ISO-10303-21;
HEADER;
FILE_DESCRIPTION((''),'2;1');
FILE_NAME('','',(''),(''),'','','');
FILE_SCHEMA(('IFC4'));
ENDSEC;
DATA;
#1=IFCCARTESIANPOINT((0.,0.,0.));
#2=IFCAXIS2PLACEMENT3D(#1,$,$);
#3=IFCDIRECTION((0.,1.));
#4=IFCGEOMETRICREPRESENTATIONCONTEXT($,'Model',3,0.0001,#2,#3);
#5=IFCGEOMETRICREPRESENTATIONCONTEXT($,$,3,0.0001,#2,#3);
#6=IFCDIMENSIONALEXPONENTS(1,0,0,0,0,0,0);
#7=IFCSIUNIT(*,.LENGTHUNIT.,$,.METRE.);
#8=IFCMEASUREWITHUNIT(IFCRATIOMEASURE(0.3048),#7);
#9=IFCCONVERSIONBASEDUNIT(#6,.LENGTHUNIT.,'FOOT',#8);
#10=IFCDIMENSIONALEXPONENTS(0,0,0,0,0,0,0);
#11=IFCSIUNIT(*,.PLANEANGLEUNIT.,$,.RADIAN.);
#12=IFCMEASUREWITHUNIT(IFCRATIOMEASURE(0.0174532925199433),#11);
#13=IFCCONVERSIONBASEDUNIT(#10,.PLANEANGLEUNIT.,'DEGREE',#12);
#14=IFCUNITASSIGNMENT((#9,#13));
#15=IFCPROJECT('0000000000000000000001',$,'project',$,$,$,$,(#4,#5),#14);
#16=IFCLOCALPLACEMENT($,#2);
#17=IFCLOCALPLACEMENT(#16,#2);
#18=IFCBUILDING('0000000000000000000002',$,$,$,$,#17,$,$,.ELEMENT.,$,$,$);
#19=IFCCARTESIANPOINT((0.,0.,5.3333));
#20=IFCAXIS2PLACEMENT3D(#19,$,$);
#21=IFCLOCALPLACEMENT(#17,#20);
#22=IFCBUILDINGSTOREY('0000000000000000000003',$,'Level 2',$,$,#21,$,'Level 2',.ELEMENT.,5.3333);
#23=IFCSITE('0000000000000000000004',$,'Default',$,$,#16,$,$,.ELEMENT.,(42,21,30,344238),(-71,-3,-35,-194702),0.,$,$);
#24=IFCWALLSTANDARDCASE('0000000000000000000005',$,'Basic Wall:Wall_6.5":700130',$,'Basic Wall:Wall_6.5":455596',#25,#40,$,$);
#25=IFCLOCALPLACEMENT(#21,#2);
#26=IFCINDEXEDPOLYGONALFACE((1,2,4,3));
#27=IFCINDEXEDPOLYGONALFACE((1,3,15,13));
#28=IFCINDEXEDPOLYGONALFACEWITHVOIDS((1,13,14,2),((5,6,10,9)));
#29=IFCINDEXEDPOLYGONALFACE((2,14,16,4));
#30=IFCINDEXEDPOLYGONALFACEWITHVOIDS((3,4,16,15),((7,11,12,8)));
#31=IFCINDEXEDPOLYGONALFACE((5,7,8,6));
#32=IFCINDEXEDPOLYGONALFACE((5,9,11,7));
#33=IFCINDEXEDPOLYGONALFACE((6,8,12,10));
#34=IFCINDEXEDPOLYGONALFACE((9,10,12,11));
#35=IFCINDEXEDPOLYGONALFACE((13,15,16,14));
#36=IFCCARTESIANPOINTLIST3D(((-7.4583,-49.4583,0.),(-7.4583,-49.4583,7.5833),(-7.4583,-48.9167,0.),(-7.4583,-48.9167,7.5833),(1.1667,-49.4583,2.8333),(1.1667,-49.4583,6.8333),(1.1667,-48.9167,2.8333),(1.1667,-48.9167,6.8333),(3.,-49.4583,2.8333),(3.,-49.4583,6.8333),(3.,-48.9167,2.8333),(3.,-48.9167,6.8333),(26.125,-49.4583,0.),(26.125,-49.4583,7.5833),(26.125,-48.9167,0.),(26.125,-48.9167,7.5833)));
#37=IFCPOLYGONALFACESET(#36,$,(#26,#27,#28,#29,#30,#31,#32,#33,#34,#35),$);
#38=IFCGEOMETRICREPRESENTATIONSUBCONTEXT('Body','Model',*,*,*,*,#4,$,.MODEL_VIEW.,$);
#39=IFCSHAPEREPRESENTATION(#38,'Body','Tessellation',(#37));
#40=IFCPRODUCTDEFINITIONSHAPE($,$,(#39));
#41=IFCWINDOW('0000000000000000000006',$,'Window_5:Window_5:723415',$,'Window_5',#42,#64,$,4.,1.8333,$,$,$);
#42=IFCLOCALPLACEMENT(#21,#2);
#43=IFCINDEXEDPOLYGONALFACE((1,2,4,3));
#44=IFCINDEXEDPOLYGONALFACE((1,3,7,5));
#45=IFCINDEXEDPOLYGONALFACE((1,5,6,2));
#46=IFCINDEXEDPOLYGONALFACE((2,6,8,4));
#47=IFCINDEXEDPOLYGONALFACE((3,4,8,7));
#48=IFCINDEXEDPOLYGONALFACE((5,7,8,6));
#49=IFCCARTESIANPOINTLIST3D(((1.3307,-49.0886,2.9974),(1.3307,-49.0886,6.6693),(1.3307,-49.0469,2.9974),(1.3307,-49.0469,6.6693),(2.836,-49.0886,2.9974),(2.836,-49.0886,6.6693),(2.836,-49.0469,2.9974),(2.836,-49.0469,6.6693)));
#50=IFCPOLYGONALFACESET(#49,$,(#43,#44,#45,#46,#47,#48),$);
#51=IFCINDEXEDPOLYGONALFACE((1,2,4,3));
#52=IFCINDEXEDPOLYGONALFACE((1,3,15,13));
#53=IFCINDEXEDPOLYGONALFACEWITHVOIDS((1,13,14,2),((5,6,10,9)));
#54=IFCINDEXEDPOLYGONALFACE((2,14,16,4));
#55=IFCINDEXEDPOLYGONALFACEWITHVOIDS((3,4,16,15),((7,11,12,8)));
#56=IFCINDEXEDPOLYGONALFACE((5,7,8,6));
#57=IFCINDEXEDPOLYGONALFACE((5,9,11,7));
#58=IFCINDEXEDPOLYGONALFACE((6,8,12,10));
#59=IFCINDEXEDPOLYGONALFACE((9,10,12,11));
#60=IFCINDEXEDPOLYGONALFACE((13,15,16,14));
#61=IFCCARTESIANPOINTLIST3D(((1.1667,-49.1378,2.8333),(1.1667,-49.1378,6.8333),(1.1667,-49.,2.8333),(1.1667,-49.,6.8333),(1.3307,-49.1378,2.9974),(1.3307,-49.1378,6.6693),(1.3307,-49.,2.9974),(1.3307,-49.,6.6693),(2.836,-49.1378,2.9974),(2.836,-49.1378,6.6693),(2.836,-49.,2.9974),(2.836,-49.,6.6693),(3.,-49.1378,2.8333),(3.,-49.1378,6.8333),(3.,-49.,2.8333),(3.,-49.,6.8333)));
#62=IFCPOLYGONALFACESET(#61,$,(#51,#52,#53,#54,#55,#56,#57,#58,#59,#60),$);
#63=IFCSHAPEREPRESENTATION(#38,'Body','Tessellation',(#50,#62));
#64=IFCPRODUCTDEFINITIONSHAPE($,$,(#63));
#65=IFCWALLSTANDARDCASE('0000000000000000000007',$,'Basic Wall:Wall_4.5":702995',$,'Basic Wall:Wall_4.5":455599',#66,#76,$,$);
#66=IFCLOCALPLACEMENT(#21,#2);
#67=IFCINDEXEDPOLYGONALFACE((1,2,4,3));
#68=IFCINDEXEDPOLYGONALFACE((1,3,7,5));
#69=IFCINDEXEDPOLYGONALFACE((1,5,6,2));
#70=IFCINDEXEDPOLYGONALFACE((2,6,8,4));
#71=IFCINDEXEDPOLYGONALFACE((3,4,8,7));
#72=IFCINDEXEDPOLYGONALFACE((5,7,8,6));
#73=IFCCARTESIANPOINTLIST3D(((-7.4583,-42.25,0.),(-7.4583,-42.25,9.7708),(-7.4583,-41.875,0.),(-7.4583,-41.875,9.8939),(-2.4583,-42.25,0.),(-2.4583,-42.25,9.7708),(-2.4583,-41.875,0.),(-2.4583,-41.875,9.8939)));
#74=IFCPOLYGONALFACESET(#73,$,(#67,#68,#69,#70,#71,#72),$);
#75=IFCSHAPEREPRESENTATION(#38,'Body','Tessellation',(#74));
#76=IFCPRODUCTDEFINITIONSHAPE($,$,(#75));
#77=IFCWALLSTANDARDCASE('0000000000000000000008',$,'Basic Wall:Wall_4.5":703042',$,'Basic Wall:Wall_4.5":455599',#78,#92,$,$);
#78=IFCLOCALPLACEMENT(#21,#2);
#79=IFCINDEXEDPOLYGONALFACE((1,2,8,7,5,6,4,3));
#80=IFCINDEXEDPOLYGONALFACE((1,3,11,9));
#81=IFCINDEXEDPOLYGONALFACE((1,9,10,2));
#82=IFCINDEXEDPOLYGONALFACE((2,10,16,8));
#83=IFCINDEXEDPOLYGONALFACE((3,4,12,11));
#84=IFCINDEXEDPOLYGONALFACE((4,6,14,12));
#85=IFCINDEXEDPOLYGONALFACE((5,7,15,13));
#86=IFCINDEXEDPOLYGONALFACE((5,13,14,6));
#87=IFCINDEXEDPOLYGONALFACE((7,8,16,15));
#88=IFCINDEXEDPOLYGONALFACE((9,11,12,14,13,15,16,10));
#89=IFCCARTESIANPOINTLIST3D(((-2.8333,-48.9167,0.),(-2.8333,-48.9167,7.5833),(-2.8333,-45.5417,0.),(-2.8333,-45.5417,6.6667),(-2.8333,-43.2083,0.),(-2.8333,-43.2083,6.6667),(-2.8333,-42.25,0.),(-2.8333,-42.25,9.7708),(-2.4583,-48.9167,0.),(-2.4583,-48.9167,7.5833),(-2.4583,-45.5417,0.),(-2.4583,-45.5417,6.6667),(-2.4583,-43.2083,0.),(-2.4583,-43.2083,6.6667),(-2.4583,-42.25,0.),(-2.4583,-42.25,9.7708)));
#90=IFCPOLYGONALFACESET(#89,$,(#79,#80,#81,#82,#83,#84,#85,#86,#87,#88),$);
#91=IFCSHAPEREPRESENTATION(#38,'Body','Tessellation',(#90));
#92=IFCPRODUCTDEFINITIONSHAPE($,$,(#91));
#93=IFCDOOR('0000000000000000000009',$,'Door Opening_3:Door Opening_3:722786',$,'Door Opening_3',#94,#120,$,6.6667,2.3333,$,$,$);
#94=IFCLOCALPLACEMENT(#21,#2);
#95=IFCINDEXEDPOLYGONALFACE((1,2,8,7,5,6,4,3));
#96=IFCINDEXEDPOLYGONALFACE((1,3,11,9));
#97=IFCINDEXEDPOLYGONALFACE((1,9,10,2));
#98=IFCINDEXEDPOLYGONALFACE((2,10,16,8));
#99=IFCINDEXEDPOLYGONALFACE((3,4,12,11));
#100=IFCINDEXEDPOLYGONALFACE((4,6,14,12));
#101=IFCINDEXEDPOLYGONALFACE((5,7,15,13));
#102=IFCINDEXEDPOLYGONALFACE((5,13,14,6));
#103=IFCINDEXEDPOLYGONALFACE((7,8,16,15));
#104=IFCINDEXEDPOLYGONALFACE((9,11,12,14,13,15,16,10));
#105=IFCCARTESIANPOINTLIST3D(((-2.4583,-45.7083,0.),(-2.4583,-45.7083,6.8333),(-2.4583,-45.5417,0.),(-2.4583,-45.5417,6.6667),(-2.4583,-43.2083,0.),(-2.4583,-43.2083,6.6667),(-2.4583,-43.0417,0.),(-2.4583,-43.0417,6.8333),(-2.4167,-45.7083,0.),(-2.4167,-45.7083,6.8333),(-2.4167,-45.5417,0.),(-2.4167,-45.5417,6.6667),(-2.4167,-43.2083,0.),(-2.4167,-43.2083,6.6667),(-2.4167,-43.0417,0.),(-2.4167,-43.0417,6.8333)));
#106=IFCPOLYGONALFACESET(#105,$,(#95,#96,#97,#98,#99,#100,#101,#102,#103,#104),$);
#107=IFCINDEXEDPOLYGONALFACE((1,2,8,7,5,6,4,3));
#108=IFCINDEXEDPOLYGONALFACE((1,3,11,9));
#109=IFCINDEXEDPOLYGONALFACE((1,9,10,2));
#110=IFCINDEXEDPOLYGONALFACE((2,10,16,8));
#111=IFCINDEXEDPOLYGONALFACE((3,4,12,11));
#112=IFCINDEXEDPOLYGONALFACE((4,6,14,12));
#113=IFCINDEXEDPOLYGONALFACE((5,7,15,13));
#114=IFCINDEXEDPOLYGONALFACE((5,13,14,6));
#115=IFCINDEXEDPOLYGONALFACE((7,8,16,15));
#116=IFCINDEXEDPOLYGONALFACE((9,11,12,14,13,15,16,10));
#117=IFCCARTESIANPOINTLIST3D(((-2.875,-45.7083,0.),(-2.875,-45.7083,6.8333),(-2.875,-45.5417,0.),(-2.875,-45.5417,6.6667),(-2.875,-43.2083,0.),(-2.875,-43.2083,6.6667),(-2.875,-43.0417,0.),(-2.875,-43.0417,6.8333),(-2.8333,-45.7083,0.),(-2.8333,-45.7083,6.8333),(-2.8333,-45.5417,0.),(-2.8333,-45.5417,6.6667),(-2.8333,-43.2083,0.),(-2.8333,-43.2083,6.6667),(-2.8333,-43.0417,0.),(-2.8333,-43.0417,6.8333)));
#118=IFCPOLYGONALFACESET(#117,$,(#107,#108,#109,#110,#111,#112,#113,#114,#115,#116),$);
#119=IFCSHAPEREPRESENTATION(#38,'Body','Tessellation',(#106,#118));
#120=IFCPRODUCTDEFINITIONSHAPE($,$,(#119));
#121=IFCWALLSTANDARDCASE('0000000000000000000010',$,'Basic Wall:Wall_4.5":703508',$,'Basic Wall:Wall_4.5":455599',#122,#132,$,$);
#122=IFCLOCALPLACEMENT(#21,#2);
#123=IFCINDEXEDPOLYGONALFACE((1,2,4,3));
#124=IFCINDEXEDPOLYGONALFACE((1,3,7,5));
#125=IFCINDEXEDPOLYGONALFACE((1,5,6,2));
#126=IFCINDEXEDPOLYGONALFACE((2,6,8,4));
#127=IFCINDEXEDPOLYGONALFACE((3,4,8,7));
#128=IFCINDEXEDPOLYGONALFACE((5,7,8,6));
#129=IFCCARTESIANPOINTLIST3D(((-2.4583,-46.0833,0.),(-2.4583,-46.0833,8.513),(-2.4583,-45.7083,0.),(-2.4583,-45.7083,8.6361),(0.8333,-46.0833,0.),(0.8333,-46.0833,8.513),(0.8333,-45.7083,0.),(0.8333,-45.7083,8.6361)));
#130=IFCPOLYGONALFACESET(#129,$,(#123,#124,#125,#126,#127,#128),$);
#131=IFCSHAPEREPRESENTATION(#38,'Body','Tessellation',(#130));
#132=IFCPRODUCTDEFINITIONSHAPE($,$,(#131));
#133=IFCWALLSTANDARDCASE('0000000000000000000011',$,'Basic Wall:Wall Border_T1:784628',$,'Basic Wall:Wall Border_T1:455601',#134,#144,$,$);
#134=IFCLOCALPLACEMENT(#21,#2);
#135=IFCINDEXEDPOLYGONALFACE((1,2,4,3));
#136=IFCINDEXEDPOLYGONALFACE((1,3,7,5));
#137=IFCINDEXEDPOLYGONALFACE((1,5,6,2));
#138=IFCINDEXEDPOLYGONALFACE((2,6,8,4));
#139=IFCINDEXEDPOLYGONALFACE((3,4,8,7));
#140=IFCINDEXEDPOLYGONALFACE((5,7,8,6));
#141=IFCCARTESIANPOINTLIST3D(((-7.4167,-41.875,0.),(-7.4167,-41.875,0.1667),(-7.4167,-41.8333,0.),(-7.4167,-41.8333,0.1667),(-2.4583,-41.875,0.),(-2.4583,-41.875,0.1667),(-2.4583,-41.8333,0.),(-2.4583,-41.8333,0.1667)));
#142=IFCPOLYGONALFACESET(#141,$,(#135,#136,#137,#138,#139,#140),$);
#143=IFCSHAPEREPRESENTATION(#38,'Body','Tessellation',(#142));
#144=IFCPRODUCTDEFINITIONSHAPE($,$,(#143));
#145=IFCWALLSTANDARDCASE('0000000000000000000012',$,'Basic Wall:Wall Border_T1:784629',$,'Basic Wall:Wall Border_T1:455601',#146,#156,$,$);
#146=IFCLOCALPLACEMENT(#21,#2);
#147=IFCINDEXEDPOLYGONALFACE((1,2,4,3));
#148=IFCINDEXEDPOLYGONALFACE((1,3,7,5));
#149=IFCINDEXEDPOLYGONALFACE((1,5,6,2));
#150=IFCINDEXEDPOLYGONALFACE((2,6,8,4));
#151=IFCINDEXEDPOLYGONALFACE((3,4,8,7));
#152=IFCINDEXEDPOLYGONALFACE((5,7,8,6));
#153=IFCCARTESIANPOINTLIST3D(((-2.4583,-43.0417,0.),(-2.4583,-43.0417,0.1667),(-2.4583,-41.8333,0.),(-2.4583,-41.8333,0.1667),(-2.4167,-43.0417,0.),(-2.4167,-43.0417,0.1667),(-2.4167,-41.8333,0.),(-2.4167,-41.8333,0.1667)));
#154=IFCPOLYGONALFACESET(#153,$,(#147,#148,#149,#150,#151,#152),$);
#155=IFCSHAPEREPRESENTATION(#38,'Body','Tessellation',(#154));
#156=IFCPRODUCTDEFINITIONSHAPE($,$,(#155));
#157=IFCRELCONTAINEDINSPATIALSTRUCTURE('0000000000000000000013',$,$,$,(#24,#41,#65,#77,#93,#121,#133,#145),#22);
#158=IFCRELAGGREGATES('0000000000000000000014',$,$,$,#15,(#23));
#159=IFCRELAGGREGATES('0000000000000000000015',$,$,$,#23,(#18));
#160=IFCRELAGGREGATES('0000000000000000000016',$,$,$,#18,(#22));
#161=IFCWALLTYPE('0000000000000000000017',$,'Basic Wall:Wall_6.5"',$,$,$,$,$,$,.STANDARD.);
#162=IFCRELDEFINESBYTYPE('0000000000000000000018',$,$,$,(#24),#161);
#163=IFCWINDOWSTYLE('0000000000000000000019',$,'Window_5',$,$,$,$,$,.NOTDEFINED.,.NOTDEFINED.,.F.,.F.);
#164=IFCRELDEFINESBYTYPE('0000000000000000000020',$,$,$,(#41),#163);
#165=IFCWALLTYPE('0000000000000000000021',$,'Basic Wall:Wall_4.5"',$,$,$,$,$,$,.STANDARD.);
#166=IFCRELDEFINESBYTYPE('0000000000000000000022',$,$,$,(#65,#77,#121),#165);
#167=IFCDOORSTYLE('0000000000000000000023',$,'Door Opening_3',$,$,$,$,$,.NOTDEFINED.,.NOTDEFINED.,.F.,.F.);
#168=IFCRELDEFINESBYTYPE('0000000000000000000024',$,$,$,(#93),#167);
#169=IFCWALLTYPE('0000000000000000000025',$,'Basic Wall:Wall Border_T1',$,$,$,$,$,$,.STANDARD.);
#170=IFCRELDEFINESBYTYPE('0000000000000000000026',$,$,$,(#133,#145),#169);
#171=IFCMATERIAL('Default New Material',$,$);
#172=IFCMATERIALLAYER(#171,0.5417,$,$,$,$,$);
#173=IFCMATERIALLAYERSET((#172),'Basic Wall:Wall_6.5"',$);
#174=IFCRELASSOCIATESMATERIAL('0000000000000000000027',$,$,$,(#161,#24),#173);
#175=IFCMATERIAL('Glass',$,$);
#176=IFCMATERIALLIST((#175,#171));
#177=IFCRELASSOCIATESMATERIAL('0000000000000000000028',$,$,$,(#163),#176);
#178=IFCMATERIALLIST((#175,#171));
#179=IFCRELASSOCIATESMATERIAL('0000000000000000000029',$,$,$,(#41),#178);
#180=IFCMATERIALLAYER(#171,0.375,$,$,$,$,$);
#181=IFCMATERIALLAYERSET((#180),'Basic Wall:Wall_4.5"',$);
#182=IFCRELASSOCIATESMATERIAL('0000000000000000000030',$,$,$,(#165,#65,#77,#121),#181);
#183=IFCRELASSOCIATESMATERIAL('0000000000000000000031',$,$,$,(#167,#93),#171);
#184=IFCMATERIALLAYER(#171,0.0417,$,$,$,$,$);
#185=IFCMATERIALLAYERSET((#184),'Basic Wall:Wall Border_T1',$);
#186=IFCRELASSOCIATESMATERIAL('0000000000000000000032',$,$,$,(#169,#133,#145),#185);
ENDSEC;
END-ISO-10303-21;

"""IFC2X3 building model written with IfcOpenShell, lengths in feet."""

from ifc_helpers import new_model, entity, si_unit, converted_unit, direction, frame, frame_2d, origin, origin_2d_with_axis, place, context, subcontext, project, spatial, polyline, rectangle, outline, extrude, clip, bounded_halfspace, source, transform, mapped, material, material_list, layer, layer_set, layer_usage, type_object, type_shapes, element, fill, save


model = new_model("IFC2X3")

# Units and contexts
model_context = context("Model", 3, precision=0.0001, world=origin(), true_north=direction((0.0, 1.0)))
context_of_model = context(None, 3, precision=0.0001, world=origin(), true_north=direction((0.0, 1.0)))
body_context = subcontext(model_context, "Body", "Model", "MODEL_VIEW")
ifc_project = project(units=[converted_unit("LENGTHUNIT", "FOOT", entity("IfcRatioMeasure", 0.3048), si_unit("LENGTHUNIT", "METRE"), dimensions=[1, 0, 0, 0, 0, 0, 0]), converted_unit("PLANEANGLEUNIT", "DEGREE", entity("IfcRatioMeasure", 0.0174532925199433), si_unit("PLANEANGLEUNIT", "RADIAN"), dimensions=[0, 0, 0, 0, 0, 0, 0])], contexts=[model_context, context_of_model])

# Site, building, storey
site_placement = place(None, origin())
site = spatial("IfcSite", under=ifc_project, at=site_placement, Name="Default", CompositionType="ELEMENT", RefLatitude=(42, 21, 30, 344238), RefLongitude=(-71, -3, -35, -194702), RefElevation=0.0)
building_placement = place(site_placement, origin())
building = spatial("IfcBuilding", under=site, at=building_placement, CompositionType="ELEMENT")
storey_placement = place(building_placement, frame((0.0, 0.0, 5.3333)))
storey = spatial("IfcBuildingStorey", under=building, at=storey_placement, Name="Level 2", LongName="Level 2", CompositionType="ELEMENT", Elevation=5.3333)

# Wall, opening, window
ifc_material_1 = material(Name="Default New Material")
ifc_layer_1 = layer(ifc_material_1, 0.5417)
ifc_layer_set_1 = layer_set([ifc_layer_1], Name="Basic Wall:Wall_6.5\"")
ifc_layer_usage_1 = layer_usage(ifc_layer_set_1, "AXIS2", "NEGATIVE", 0.2708)
wall_type_1 = type_object("IfcWallType", Name="Basic Wall:Wall_6.5\"", PredefinedType="STANDARD", material=ifc_layer_set_1)
wall_1_placement = place(storey_placement, frame((-7.4583, -49.1875, 0.0)))
wall_1 = element("IfcWallStandardCase", 1, at=wall_1_placement, inside=storey, type_object=wall_type_1, material=ifc_layer_usage_1, Name="Basic Wall:Wall_6.5\":700130", ObjectType="Basic Wall:Wall_6.5\":455596", context=body_context, shape_type="SweptSolid", body=[
    extrude(rectangle(XDim=33.5833, YDim=0.5417, at=frame_2d((16.7917, 0.0), x_axis=(-1.0, 0.0))), origin(), (0.0, 0.0, 1.0), 7.5833),
])
opening_1_placement = place(wall_1_placement, frame((8.625, -0.2708, 2.8333)))
opening_1 = element("IfcOpeningElement", 2, at=opening_1_placement, cuts=wall_1, ObjectType="Opening", context=body_context, shape_type="SweptSolid", body=[
    extrude(rectangle(XDim=4.0, YDim=1.8333, at=frame_2d((2.0, 0.9167), x_axis=(-1.0, 0.0))), frame((0.0, 0.0, 0.0), z_axis=(0.0, 1.0, 0.0), x_axis=(0.0, 0.0, 1.0)), (0.0, 0.0, 1.0), 0.5417),
])
ifc_material_2 = material(Name="Glass")
ifc_material_list_1 = material_list([ifc_material_2, ifc_material_1])
ifc_material_list_2 = material_list([ifc_material_2, ifc_material_1])
window_style = type_object("IfcWindowStyle", Name="Window_5", ConstructionType="NOTDEFINED", OperationType="NOTDEFINED", ParameterTakesPrecedence=False, Sizeable=False, material=ifc_material_list_2)
shared_shape_1 = source(origin(), body_context, "Body", "SweptSolid", [
    extrude(rectangle(XDim=0.0417, YDim=1.5052, at=origin_2d_with_axis()), frame((0.9167, 0.3906, 0.164), z_axis=(0.0, 0.0, 1.0), x_axis=(0.0, 1.0, 0.0)), (0.0, 0.0, 1.0), 3.6719),
    extrude(outline(polyline([(-0.9167, -2.0), (0.9167, -2.0), (0.9167, 2.0), (-0.9167, 2.0), (-0.9167, -2.0)]), holes=[polyline([(-0.7526, -1.836), (-0.7526, 1.836), (0.7526, 1.836), (0.7526, -1.836), (-0.7526, -1.836)])]), frame((0.9167, 0.3205, 2.0), z_axis=(0.0, 1.0, 0.0), x_axis=(1.0, 0.0, 0.0)), (0.0, 0.0, 1.0), 0.1378),
])
type_shapes(window_style, [shared_shape_1])
window_placement = place(opening_1_placement, origin())
window = element("IfcWindow", 3, at=window_placement, inside=storey, type_object=window_style, material=ifc_material_list_1, Name="Window_5:Window_5:723415", ObjectType="Window_5", OverallHeight=4.0, OverallWidth=1.8333, context=body_context, shape_type="MappedRepresentation", body=[
    mapped(shared_shape_1, transform((0.0, 0.0, 0.0), scale=1.0)),
])
fill(opening_1, window)

# Wall
ifc_layer_2 = layer(ifc_material_1, 0.375)
ifc_layer_set_2 = layer_set([ifc_layer_2], Name="Basic Wall:Wall_4.5\"")
ifc_layer_usage_2 = layer_usage(ifc_layer_set_2, "AXIS2", "NEGATIVE", 0.1875)
wall_type_2 = type_object("IfcWallType", Name="Basic Wall:Wall_4.5\"", PredefinedType="STANDARD", material=ifc_layer_set_2)
wall_2_placement = place(storey_placement, frame((-7.4583, -42.0625, 0.0)))
element("IfcWallStandardCase", 4, at=wall_2_placement, inside=storey, type_object=wall_type_2, material=ifc_layer_usage_2, Name="Basic Wall:Wall_4.5\":702995", ObjectType="Basic Wall:Wall_4.5\":455599", context=body_context, shape_type="Clipping", body=[
    clip(extrude(rectangle(XDim=5.0, YDim=0.375, at=frame_2d((2.5, 0.0), x_axis=(-1.0, 0.0))), origin(), (0.0, 0.0, 1.0), 9.8939), bounded_halfspace(frame((0.0, -0.1875, 9.7708), z_axis=(0.0, 0.31177, -0.950157), x_axis=(1.0, 0.0, 0.0)), True, frame((0.0, -0.1875, 9.7708)), polyline([(0.0, 0.0), (4.625, 0.0), (5.0, 0.0), (5.0, 0.375), (0.0, 0.375), (0.0, 0.0)]))),
])

# Wall, opening, door
ifc_layer_usage_3 = layer_usage(ifc_layer_set_2, "AXIS2", "NEGATIVE", 0.1875)
wall_3_placement = place(storey_placement, frame((-2.6458, -42.25, 0.0), z_axis=(0.0, 0.0, 1.0), x_axis=(0.0, -1.0, 0.0)))
wall_3 = element("IfcWallStandardCase", 5, at=wall_3_placement, inside=storey, type_object=wall_type_2, material=ifc_layer_usage_3, Name="Basic Wall:Wall_4.5\":703042", ObjectType="Basic Wall:Wall_4.5\":455599", context=body_context, shape_type="Clipping", body=[
    clip(extrude(rectangle(XDim=6.6667, YDim=0.375, at=frame_2d((3.3333, 0.0), x_axis=(-1.0, 0.0))), origin(), (0.0, 0.0, 1.0), 9.7708), bounded_halfspace(frame((0.0, -0.1875, 9.7708), z_axis=(-0.31177, 0.0, -0.950157), x_axis=(0.0, 1.0, 0.0)), True, frame((0.0, -0.1875, 9.7708)), polyline([(0.0, 0.0), (6.6667, 0.0), (6.6667, 0.375), (3.8333, 0.375), (3.4583, 0.375), (0.0, 0.375), (0.0, 0.0)]))),
])
opening_2_placement = place(wall_3_placement, frame((0.9583, -0.1875, 0.0)))
opening_2 = element("IfcOpeningElement", 6, at=opening_2_placement, cuts=wall_3, ObjectType="Opening", context=body_context, shape_type="SweptSolid", body=[
    extrude(rectangle(XDim=2.3333, YDim=6.6667, at=frame_2d((3.3333, 1.1667), x_axis=(0.0, 1.0))), frame((0.0, 0.0, 0.0), z_axis=(0.0, 1.0, 0.0), x_axis=(0.0, 0.0, 1.0)), (0.0, 0.0, 1.0), 0.375),
])
door_style = type_object("IfcDoorStyle", Name="Door Opening_3", ConstructionType="NOTDEFINED", OperationType="NOTDEFINED", ParameterTakesPrecedence=False, Sizeable=False, material=ifc_material_1)
shared_shape_2 = source(origin(), body_context, "Body", "SweptSolid", [
    extrude(outline(polyline([(-1.3333, -3.4583), (1.3333, -3.4583), (1.3333, 3.375), (1.1667, 3.375), (1.1667, -3.2917), (-1.1667, -3.2917), (-1.1667, 3.375), (-1.3333, 3.375), (-1.3333, -3.4583)])), frame((1.1667, 0.375, 3.375), z_axis=(0.0, 1.0, 0.0), x_axis=(1.0, 0.0, 0.0)), (0.0, 0.0, 1.0), 0.0417),
    extrude(outline(polyline([(-3.4583, -1.3333), (3.375, -1.3333), (3.375, -1.1667), (-3.2917, -1.1667), (-3.2917, 1.1667), (3.375, 1.1667), (3.375, 1.3333), (-3.4583, 1.3333), (-3.4583, -1.3333)])), frame((1.1667, -0.0417, 3.375), z_axis=(0.0, 1.0, 0.0), x_axis=(0.0, 0.0, -1.0)), (0.0, 0.0, 1.0), 0.0417),
])
type_shapes(door_style, [shared_shape_2])
door_placement = place(opening_2_placement, origin())
door = element("IfcDoor", 7, at=door_placement, inside=storey, type_object=door_style, material=ifc_material_1, Name="Door Opening_3:Door Opening_3:722786", ObjectType="Door Opening_3", OverallHeight=6.6667, OverallWidth=2.3333, context=body_context, shape_type="MappedRepresentation", body=[
    mapped(shared_shape_2, transform((0.0, 0.0, 0.0), scale=1.0)),
])
fill(opening_2, door)

# Walls
ifc_layer_usage_4 = layer_usage(ifc_layer_set_2, "AXIS2", "NEGATIVE", 0.1875)
wall_4_placement = place(storey_placement, frame((-2.4583, -45.8958, 0.0)))
element("IfcWallStandardCase", 8, at=wall_4_placement, inside=storey, type_object=wall_type_2, material=ifc_layer_usage_4, Name="Basic Wall:Wall_4.5\":703508", ObjectType="Basic Wall:Wall_4.5\":455599", context=body_context, shape_type="Clipping", body=[
    clip(extrude(rectangle(XDim=3.2917, YDim=0.375, at=frame_2d((1.6458, 0.0), x_axis=(-1.0, 0.0))), origin(), (0.0, 0.0, 1.0), 8.6361), bounded_halfspace(frame((0.0, -0.1875, 8.513), z_axis=(0.0, 0.31177, -0.950157), x_axis=(1.0, 0.0, 0.0)), True, frame((0.0, -0.1875, 8.513)), polyline([(0.0, 0.0), (3.2917, 0.0), (3.2917, 0.375), (0.0, 0.375), (0.0, 0.0)]))),
])
ifc_layer_3 = layer(ifc_material_1, 0.0417)
ifc_layer_set_3 = layer_set([ifc_layer_3], Name="Basic Wall:Wall Border_T1")
ifc_layer_usage_5 = layer_usage(ifc_layer_set_3, "AXIS2", "NEGATIVE", 0.0208)
wall_type_3 = type_object("IfcWallType", Name="Basic Wall:Wall Border_T1", PredefinedType="STANDARD", material=ifc_layer_set_3)
wall_5_placement = place(storey_placement, frame((-7.4167, -41.8542, 0.0)))
element("IfcWallStandardCase", 9, at=wall_5_placement, inside=storey, type_object=wall_type_3, material=ifc_layer_usage_5, Name="Basic Wall:Wall Border_T1:784628", ObjectType="Basic Wall:Wall Border_T1:455601", context=body_context, shape_type="SweptSolid", body=[
    extrude(rectangle(XDim=4.9583, YDim=0.0417, at=frame_2d((2.4792, 0.0), x_axis=(-1.0, 0.0))), origin(), (0.0, 0.0, 1.0), 0.1667),
])
ifc_layer_usage_6 = layer_usage(ifc_layer_set_3, "AXIS2", "NEGATIVE", 0.0208)
wall_6_placement = place(storey_placement, frame((-2.4375, -41.8333, 0.0), z_axis=(0.0, 0.0, 1.0), x_axis=(0.0, -1.0, 0.0)))
element("IfcWallStandardCase", 10, at=wall_6_placement, inside=storey, type_object=wall_type_3, material=ifc_layer_usage_6, Name="Basic Wall:Wall Border_T1:784629", ObjectType="Basic Wall:Wall Border_T1:455601", context=body_context, shape_type="SweptSolid", body=[
    extrude(rectangle(XDim=1.2083, YDim=0.0417, at=frame_2d((0.6042, 0.0), x_axis=(-1.0, 0.0))), origin(), (0.0, 0.0, 1.0), 0.1667),
])

save(model, "model.ifc")
